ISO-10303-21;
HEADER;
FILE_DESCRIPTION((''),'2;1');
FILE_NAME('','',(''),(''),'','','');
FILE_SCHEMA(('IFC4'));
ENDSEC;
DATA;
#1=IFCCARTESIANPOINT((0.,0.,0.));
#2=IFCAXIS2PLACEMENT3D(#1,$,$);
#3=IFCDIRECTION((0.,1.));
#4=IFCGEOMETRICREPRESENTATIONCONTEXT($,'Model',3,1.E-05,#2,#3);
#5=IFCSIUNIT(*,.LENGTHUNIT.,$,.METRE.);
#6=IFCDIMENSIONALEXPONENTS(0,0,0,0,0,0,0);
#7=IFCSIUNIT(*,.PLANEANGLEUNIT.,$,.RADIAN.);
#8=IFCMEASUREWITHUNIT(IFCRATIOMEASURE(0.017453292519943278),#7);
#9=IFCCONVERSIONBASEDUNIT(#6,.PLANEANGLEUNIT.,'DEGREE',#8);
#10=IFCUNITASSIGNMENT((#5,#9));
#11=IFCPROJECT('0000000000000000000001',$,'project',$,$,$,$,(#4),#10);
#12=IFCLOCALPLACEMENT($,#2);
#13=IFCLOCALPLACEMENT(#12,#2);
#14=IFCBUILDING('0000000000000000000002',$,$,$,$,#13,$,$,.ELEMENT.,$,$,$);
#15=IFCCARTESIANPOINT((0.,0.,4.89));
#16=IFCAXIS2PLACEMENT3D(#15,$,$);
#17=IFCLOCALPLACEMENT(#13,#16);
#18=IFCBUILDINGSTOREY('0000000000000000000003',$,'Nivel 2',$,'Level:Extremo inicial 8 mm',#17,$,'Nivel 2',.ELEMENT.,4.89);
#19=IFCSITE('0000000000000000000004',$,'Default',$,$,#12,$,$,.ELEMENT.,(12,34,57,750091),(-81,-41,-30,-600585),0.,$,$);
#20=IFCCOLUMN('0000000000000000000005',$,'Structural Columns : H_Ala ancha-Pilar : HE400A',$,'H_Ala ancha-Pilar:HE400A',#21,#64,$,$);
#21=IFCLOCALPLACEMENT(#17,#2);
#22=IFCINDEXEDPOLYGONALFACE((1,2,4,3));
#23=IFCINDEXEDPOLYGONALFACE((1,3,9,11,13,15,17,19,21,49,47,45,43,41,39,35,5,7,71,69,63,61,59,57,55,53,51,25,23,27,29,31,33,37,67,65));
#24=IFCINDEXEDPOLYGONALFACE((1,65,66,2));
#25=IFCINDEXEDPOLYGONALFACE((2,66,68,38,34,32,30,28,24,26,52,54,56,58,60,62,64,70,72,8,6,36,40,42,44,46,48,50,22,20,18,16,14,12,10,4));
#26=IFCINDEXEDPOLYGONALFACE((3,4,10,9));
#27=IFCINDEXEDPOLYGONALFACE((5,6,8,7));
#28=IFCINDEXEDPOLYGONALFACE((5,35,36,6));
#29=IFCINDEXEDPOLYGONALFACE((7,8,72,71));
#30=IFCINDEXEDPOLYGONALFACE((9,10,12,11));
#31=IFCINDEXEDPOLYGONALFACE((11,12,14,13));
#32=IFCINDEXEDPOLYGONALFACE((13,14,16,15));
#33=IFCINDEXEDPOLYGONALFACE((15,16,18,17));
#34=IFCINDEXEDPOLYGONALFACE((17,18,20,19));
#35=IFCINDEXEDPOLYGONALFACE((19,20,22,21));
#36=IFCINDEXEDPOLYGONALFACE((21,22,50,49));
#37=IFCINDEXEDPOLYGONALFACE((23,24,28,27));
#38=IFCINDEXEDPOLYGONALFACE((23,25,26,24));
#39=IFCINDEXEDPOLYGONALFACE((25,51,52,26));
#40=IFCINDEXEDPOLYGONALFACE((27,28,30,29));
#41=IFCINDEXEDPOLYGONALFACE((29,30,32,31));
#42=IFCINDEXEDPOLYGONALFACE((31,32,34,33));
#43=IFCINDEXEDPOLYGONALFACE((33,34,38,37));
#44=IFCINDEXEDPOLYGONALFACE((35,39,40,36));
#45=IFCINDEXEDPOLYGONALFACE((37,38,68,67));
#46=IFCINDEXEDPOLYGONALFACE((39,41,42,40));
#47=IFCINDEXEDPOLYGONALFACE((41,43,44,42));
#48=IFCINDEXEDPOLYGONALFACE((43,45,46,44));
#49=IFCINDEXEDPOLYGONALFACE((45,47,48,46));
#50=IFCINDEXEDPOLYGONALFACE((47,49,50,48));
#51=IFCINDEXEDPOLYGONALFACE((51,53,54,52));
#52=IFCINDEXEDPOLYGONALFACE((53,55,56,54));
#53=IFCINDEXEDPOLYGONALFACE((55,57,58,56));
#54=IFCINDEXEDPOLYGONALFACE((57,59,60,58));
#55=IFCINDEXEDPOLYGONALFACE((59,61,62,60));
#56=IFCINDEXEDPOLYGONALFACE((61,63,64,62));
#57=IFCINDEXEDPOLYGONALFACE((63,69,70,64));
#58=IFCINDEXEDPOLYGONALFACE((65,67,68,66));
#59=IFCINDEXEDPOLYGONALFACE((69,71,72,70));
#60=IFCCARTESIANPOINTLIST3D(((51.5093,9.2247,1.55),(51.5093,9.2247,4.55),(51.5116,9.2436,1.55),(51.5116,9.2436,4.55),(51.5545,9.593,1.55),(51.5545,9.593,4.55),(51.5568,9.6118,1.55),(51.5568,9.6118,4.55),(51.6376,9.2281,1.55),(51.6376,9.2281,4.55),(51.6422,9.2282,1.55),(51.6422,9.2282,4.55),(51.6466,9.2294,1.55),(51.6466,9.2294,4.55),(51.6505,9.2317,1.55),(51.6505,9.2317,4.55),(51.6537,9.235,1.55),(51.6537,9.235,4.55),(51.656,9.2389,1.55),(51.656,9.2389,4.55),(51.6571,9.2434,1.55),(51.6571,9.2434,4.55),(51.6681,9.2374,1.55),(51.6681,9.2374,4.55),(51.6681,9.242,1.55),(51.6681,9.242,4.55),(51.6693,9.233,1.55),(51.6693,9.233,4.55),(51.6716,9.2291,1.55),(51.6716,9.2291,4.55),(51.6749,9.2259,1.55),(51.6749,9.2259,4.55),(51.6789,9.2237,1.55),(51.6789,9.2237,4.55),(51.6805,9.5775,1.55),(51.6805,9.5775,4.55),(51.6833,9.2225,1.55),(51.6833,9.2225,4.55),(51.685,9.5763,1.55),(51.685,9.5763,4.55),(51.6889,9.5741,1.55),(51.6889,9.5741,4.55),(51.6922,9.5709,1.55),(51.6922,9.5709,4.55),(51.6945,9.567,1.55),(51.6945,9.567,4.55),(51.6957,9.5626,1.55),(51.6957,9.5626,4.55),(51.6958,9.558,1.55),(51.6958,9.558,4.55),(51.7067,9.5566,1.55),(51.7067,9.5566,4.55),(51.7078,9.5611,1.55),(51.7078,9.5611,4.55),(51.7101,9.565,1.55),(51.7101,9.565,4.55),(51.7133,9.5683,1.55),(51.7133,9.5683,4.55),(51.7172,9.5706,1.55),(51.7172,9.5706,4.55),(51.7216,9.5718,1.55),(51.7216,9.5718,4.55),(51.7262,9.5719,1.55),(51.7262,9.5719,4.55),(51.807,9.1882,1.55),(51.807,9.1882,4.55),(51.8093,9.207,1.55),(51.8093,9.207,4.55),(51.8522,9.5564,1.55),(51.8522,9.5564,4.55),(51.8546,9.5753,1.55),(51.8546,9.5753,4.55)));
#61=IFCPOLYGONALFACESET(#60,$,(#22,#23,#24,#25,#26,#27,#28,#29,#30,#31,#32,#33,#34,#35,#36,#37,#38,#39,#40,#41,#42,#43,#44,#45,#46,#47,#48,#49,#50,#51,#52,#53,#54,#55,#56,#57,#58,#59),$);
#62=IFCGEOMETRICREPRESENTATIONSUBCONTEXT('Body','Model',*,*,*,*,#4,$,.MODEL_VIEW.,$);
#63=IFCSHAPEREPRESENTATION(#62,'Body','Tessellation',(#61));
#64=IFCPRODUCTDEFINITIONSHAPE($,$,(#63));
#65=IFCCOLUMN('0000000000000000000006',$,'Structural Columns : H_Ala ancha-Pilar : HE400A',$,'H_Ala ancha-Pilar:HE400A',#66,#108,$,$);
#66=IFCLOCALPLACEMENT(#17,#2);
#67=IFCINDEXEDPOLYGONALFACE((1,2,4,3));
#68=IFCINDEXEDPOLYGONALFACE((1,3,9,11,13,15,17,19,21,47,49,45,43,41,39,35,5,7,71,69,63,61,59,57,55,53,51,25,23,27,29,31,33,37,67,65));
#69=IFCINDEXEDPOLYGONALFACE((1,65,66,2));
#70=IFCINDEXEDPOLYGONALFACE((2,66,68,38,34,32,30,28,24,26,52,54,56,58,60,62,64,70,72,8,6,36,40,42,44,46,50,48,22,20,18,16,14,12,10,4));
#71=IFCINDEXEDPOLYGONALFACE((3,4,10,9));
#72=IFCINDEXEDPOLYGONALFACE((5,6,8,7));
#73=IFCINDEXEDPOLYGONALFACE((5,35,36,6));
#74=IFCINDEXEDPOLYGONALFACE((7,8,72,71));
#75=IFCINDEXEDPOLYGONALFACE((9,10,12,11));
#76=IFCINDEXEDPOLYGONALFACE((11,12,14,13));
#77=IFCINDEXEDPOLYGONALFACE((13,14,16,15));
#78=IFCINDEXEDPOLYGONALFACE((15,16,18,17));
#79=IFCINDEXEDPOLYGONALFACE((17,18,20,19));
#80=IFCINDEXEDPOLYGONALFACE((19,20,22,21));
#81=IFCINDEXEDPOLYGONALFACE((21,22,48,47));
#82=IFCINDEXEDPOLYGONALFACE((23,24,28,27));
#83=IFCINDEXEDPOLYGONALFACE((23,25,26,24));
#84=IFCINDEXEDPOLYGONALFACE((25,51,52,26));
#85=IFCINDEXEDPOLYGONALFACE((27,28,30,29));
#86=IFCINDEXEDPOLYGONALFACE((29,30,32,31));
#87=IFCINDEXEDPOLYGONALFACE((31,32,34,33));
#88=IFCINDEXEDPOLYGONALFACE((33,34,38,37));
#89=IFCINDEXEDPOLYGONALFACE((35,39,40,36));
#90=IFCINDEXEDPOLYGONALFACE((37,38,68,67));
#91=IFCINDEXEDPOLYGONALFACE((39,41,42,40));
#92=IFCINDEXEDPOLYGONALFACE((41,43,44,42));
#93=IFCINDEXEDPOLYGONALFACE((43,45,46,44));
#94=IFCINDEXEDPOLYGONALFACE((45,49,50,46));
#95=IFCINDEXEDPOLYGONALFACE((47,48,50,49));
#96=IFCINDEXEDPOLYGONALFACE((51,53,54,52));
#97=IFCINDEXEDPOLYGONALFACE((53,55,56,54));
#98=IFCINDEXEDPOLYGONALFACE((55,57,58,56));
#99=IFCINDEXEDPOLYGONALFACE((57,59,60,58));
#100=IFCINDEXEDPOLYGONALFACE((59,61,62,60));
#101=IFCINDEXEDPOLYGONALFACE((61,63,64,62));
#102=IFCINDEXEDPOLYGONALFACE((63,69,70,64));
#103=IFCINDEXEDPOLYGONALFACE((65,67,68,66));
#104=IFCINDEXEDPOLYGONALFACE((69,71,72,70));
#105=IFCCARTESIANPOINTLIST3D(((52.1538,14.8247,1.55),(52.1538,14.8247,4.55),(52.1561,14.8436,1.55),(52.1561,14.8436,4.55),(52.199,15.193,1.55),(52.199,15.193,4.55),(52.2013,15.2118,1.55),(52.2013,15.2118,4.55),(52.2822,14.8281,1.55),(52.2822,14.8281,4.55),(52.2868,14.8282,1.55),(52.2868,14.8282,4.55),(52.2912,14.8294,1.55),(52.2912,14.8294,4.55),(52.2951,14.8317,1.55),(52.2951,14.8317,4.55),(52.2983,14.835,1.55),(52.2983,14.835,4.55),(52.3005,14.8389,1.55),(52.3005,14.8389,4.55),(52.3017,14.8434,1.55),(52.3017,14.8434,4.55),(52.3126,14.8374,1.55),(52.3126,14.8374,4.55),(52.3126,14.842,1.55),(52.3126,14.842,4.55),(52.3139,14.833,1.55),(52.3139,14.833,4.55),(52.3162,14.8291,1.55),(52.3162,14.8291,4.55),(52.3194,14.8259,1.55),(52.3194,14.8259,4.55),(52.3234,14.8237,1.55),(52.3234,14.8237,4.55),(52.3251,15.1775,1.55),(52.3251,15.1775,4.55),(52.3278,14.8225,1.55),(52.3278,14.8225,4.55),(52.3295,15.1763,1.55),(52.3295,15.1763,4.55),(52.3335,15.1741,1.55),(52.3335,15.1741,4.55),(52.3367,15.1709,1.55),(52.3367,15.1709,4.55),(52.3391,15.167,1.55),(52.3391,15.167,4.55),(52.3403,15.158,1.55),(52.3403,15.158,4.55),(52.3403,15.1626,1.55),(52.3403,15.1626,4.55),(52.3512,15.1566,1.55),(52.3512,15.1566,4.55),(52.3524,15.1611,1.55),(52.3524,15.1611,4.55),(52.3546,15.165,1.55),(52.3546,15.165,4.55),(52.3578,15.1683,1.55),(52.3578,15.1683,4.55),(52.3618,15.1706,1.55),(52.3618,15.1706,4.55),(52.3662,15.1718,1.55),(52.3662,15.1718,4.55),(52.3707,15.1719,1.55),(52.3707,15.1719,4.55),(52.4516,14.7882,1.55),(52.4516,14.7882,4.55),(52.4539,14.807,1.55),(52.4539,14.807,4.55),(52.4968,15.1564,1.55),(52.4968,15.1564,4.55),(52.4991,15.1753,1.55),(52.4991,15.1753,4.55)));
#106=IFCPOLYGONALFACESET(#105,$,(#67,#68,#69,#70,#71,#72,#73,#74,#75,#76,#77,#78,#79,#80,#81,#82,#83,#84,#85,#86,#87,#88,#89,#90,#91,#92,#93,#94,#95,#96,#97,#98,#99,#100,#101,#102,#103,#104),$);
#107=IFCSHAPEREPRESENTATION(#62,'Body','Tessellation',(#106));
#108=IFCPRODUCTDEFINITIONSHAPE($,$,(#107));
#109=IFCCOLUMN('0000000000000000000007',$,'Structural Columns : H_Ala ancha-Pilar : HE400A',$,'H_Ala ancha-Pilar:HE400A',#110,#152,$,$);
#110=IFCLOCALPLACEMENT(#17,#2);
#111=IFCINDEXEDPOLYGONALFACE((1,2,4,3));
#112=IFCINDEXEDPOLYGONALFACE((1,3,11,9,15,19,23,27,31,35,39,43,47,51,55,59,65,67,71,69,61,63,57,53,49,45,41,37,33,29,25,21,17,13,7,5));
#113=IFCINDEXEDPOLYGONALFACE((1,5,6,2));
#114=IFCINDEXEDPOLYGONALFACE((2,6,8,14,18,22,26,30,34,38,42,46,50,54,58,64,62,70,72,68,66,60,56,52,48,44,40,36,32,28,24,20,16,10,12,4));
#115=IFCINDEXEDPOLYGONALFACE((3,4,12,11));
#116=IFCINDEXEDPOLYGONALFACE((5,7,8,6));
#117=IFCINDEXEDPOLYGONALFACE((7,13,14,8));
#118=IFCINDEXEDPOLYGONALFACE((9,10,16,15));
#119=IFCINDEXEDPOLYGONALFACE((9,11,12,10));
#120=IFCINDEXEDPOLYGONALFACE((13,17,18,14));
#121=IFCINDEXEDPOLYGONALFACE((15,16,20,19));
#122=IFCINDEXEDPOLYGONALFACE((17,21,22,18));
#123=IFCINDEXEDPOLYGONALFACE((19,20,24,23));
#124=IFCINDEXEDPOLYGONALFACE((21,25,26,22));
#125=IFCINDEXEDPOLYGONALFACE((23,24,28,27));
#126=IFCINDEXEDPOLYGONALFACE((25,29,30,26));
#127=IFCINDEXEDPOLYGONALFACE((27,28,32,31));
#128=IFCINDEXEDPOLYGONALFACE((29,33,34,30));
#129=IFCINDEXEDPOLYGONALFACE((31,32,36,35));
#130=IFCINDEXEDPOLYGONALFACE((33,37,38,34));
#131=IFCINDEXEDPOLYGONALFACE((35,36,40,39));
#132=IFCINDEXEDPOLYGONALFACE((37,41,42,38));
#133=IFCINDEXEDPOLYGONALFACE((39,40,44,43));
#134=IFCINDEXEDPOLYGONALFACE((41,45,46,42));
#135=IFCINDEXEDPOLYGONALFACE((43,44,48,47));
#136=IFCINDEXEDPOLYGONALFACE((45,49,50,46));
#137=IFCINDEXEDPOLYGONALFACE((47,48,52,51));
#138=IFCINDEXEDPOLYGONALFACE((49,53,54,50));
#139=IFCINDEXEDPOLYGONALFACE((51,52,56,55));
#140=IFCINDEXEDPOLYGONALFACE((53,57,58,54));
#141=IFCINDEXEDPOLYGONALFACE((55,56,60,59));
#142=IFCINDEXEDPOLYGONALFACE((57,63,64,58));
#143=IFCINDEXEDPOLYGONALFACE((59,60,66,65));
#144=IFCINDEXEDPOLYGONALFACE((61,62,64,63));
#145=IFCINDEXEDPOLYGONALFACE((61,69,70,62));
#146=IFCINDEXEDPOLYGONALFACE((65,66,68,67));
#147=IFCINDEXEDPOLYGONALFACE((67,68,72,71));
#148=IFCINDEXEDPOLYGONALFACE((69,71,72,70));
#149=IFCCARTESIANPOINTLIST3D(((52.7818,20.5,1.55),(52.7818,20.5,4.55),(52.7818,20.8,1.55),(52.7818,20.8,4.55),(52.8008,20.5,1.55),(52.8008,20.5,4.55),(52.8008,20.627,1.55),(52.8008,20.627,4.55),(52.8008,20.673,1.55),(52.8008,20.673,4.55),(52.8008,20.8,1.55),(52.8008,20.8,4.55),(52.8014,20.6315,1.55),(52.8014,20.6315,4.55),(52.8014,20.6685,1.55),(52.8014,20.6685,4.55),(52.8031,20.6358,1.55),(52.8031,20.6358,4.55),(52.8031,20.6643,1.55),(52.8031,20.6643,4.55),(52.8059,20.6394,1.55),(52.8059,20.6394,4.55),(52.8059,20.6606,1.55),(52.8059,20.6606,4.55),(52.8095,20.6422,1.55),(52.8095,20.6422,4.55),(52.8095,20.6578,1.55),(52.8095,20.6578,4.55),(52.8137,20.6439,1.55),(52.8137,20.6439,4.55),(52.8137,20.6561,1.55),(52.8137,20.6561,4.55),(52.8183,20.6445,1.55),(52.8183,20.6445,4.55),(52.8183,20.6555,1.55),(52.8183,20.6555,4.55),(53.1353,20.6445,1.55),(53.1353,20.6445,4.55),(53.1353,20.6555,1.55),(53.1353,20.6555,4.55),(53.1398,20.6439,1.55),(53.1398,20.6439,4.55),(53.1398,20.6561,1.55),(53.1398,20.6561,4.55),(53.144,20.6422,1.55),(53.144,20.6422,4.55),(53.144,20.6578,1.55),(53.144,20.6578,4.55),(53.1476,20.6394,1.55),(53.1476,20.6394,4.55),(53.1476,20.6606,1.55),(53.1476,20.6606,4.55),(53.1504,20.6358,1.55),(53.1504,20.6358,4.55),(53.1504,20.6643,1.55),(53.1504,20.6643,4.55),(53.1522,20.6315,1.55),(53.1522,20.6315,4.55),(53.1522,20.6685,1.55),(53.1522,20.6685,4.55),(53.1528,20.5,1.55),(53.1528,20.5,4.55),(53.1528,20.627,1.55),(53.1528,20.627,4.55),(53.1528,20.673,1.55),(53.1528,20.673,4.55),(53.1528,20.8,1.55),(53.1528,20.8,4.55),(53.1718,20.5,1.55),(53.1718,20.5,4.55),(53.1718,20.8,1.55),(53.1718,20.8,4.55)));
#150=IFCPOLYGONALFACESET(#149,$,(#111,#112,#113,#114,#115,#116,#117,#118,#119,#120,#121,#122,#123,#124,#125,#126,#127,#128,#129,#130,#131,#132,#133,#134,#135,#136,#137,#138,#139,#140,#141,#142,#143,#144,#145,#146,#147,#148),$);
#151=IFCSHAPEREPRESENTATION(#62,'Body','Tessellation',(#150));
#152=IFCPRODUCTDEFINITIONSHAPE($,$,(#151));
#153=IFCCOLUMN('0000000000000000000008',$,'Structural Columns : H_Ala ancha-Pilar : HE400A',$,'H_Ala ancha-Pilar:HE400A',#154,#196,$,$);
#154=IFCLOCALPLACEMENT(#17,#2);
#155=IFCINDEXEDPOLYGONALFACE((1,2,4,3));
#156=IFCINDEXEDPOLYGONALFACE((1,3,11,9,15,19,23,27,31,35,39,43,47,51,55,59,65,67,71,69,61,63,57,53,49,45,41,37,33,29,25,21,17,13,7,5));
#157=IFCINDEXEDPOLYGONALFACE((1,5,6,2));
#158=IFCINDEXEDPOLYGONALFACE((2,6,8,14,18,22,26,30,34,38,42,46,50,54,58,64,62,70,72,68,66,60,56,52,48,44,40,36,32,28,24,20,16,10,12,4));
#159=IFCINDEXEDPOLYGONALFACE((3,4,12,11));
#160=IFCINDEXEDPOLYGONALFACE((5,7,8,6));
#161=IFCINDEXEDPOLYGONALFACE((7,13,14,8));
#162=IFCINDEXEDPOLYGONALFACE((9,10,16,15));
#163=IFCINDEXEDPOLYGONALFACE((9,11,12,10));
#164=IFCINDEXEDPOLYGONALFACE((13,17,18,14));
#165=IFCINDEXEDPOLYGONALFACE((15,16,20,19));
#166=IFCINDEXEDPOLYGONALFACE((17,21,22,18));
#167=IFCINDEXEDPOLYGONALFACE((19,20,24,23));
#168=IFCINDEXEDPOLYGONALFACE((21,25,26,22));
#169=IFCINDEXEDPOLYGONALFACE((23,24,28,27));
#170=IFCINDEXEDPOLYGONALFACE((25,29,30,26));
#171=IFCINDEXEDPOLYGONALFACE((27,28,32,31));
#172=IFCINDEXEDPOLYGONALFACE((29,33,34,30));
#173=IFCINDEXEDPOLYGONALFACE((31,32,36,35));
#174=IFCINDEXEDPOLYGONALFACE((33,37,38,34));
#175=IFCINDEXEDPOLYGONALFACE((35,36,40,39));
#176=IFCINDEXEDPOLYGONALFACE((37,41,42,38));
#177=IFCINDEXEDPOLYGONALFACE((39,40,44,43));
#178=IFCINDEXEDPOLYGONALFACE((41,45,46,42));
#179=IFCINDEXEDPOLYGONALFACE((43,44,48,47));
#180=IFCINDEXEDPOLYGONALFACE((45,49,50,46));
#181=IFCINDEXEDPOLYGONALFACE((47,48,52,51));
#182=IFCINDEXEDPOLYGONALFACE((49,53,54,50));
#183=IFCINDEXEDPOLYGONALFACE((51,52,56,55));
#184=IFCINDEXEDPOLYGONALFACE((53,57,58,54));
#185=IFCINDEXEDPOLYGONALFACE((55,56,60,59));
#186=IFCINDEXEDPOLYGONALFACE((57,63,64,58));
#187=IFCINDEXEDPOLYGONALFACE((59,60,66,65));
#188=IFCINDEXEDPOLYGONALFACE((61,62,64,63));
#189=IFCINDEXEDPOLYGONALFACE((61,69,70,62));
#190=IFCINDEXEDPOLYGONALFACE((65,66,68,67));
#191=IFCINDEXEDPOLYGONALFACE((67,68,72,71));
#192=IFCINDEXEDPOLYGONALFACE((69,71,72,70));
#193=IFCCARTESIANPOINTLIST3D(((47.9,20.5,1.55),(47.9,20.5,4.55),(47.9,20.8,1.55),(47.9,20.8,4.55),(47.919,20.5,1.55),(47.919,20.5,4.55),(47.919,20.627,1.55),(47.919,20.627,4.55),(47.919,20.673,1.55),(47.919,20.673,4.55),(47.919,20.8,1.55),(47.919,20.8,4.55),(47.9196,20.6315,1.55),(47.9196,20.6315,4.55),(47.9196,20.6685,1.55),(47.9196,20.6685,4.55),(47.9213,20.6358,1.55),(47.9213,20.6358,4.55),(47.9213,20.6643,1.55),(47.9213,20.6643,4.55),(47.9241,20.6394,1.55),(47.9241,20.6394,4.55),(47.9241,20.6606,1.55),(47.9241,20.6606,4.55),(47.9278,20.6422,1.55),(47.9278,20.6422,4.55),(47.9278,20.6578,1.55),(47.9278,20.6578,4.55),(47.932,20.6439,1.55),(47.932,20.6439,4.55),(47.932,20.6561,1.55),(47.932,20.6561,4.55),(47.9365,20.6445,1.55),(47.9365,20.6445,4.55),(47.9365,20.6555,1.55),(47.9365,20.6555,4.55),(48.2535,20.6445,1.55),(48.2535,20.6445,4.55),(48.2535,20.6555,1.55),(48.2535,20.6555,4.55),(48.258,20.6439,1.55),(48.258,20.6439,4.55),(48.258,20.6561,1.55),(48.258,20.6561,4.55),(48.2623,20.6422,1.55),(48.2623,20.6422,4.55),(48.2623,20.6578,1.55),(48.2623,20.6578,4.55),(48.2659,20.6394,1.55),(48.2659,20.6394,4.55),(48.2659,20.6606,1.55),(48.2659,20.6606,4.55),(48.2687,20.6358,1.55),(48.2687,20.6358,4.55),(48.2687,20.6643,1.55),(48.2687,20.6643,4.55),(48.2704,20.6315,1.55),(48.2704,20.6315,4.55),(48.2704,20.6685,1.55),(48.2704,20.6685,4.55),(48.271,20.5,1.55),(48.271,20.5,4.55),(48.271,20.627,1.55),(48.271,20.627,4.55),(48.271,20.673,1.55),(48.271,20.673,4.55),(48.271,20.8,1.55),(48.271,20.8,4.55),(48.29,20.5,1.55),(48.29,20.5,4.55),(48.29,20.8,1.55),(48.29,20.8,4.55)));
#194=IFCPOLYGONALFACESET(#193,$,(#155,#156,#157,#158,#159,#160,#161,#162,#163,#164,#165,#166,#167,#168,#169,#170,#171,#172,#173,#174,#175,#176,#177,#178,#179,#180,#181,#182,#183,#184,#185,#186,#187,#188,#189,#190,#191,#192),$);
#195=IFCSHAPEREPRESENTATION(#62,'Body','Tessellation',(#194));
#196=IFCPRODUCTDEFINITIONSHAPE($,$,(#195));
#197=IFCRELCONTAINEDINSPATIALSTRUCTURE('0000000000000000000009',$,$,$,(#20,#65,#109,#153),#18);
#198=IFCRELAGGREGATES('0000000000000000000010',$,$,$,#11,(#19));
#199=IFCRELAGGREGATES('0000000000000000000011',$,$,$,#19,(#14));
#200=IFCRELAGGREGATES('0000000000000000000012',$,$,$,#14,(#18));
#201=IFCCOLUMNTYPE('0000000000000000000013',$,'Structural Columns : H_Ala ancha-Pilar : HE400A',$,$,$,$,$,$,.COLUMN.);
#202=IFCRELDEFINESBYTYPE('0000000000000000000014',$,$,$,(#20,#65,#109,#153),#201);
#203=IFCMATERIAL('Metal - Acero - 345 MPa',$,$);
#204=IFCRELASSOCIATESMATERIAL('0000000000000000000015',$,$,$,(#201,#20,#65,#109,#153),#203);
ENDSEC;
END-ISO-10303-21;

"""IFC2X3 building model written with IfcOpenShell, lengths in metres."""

from ifc_helpers import new_model, entity, si_unit, converted_unit, direction, frame, frame_2d, origin, place, context, subcontext, project, spatial, polyline, circle_curve, parameter, trimmed, segment, composite_curve, outline, extrude, source, transform, mapped, material, type_object, type_shapes, element, save


model = new_model("IFC2X3")

# Units and contexts
model_context = context("Model", 3, precision=1e-05, world=origin(), true_north=direction((0.0, 1.0)))
body_context = subcontext(model_context, "Body", "Model", "MODEL_VIEW")
ifc_project = project(units=[si_unit("LENGTHUNIT", "METRE"), converted_unit("PLANEANGLEUNIT", "DEGREE", entity("IfcRatioMeasure", 0.017453292519943278), si_unit("PLANEANGLEUNIT", "RADIAN"), dimensions=[0, 0, 0, 0, 0, 0, 0])], contexts=[model_context])

# Site, building, storey
site_placement = place(None, origin())
site = spatial("IfcSite", under=ifc_project, at=site_placement, Name="Default", CompositionType="ELEMENT", RefLatitude=(12, 34, 57, 750091), RefLongitude=(-81, -41, -30, -600585), RefElevation=0.0)
building_placement = place(site_placement, origin())
building = spatial("IfcBuilding", under=site, at=building_placement, CompositionType="ELEMENT")
storey_placement = place(building_placement, frame((0.0, 0.0, 4.89)))
storey = spatial("IfcBuildingStorey", under=building, at=storey_placement, Name="Nivel 2", ObjectType="Level:Extremo inicial 8 mm", LongName="Nivel 2", CompositionType="ELEMENT", Elevation=4.89)

# Columns
ifc_material_1 = material(Name="Metal - Acero - 345 MPa")
column_type_1 = type_object("IfcColumnType", Name="Structural Columns : H_Ala ancha-Pilar : HE400A", PredefinedType="COLUMN", material=ifc_material_1)
shared_shape_1 = source(origin(), body_context, "Body", "SweptSolid", [
    extrude(outline(composite_curve([segment(polyline([(0.176, -0.15), (0.195, -0.15)]), True, "CONTINUOUS"), segment(polyline([(0.195, -0.15), (0.195, 0.15)]), True, "CONTINUOUS"), segment(polyline([(0.195, 0.15), (0.176, 0.15)]), True, "CONTINUOUS"), segment(polyline([(0.176, 0.15), (0.176, 0.023)]), True, "CONTINUOUS"), segment(trimmed(circle_curve(frame_2d((0.1585, 0.023), x_axis=(1.0, 0.0)), 0.0175), [parameter(270.0)], [parameter(0.0)], True, "PARAMETER"), False, "CONTINUOUS"), segment(polyline([(0.1585, 0.0055), (-0.1585, 0.0055)]), True, "CONTINUOUS"), segment(trimmed(circle_curve(frame_2d((-0.1585, 0.023), x_axis=(0.0, -1.0)), 0.0175), [parameter(270.0)], [parameter(0.0)], True, "PARAMETER"), False, "CONTINUOUS"), segment(polyline([(-0.176, 0.023), (-0.176, 0.15)]), True, "CONTINUOUS"), segment(polyline([(-0.176, 0.15), (-0.195, 0.15)]), True, "CONTINUOUS"), segment(polyline([(-0.195, 0.15), (-0.195, -0.15)]), True, "CONTINUOUS"), segment(polyline([(-0.195, -0.15), (-0.176, -0.15)]), True, "CONTINUOUS"), segment(polyline([(-0.176, -0.15), (-0.176, -0.023)]), True, "CONTINUOUS"), segment(trimmed(circle_curve(frame_2d((-0.1585, -0.023), x_axis=(-1.0, 0.0)), 0.0175), [parameter(270.0)], [parameter(0.0)], True, "PARAMETER"), False, "CONTINUOUS"), segment(polyline([(-0.1585, -0.0055), (0.1585, -0.0055)]), True, "CONTINUOUS"), segment(trimmed(circle_curve(frame_2d((0.1585, -0.023), x_axis=(0.0, 1.0)), 0.0175), [parameter(270.0)], [parameter(0.0)], True, "PARAMETER"), False, "CONTINUOUS"), segment(polyline([(0.176, -0.023), (0.176, -0.15)]), True, "CONTINUOUS")], self_intersect=False)), frame((0.0, 0.0, 6.44), z_axis=(0.0, 0.0, 1.0), x_axis=(0.0, -1.0, 0.0)), (0.0, 0.0, 1.0), 3.0),
])
type_shapes(column_type_1, [shared_shape_1])
for number, where, z_axis, x_axis, name in (
    (1, (51.6819, 9.4, -4.89), (0.0, 0.0, 1.0), (0.992546, -0.121869, 0.0), "Structural Columns : H_Ala ancha-Pilar : HE400A"),
    (2, (52.3265, 15.0, -4.89), (0.0, 0.0, 1.0), (0.992546, -0.121869, 0.0), "Structural Columns : H_Ala ancha-Pilar : HE400A"),
    (3, (52.9768, 20.65, -4.89), (0.0, 0.0, 1.0), (0.0, 1.0, 0.0), "Structural Columns : H_Ala ancha-Pilar : HE400A"),
    (4, (48.095, 20.65, -4.89), (0.0, 0.0, 1.0), (0.0, 1.0, 0.0), "Structural Columns : H_Ala ancha-Pilar : HE400A"),
):
    element("IfcColumn", number, at=place(storey_placement, frame(where, z_axis=z_axis, x_axis=x_axis)), inside=storey, type_object=column_type_1, material=ifc_material_1, Name=name, ObjectType="H_Ala ancha-Pilar:HE400A", context=body_context, shape_type="MappedRepresentation", body=[
        mapped(shared_shape_1, transform((0.0, 0.0, 0.0), scale=1.0)),
    ])

save(model, "model.ifc")
